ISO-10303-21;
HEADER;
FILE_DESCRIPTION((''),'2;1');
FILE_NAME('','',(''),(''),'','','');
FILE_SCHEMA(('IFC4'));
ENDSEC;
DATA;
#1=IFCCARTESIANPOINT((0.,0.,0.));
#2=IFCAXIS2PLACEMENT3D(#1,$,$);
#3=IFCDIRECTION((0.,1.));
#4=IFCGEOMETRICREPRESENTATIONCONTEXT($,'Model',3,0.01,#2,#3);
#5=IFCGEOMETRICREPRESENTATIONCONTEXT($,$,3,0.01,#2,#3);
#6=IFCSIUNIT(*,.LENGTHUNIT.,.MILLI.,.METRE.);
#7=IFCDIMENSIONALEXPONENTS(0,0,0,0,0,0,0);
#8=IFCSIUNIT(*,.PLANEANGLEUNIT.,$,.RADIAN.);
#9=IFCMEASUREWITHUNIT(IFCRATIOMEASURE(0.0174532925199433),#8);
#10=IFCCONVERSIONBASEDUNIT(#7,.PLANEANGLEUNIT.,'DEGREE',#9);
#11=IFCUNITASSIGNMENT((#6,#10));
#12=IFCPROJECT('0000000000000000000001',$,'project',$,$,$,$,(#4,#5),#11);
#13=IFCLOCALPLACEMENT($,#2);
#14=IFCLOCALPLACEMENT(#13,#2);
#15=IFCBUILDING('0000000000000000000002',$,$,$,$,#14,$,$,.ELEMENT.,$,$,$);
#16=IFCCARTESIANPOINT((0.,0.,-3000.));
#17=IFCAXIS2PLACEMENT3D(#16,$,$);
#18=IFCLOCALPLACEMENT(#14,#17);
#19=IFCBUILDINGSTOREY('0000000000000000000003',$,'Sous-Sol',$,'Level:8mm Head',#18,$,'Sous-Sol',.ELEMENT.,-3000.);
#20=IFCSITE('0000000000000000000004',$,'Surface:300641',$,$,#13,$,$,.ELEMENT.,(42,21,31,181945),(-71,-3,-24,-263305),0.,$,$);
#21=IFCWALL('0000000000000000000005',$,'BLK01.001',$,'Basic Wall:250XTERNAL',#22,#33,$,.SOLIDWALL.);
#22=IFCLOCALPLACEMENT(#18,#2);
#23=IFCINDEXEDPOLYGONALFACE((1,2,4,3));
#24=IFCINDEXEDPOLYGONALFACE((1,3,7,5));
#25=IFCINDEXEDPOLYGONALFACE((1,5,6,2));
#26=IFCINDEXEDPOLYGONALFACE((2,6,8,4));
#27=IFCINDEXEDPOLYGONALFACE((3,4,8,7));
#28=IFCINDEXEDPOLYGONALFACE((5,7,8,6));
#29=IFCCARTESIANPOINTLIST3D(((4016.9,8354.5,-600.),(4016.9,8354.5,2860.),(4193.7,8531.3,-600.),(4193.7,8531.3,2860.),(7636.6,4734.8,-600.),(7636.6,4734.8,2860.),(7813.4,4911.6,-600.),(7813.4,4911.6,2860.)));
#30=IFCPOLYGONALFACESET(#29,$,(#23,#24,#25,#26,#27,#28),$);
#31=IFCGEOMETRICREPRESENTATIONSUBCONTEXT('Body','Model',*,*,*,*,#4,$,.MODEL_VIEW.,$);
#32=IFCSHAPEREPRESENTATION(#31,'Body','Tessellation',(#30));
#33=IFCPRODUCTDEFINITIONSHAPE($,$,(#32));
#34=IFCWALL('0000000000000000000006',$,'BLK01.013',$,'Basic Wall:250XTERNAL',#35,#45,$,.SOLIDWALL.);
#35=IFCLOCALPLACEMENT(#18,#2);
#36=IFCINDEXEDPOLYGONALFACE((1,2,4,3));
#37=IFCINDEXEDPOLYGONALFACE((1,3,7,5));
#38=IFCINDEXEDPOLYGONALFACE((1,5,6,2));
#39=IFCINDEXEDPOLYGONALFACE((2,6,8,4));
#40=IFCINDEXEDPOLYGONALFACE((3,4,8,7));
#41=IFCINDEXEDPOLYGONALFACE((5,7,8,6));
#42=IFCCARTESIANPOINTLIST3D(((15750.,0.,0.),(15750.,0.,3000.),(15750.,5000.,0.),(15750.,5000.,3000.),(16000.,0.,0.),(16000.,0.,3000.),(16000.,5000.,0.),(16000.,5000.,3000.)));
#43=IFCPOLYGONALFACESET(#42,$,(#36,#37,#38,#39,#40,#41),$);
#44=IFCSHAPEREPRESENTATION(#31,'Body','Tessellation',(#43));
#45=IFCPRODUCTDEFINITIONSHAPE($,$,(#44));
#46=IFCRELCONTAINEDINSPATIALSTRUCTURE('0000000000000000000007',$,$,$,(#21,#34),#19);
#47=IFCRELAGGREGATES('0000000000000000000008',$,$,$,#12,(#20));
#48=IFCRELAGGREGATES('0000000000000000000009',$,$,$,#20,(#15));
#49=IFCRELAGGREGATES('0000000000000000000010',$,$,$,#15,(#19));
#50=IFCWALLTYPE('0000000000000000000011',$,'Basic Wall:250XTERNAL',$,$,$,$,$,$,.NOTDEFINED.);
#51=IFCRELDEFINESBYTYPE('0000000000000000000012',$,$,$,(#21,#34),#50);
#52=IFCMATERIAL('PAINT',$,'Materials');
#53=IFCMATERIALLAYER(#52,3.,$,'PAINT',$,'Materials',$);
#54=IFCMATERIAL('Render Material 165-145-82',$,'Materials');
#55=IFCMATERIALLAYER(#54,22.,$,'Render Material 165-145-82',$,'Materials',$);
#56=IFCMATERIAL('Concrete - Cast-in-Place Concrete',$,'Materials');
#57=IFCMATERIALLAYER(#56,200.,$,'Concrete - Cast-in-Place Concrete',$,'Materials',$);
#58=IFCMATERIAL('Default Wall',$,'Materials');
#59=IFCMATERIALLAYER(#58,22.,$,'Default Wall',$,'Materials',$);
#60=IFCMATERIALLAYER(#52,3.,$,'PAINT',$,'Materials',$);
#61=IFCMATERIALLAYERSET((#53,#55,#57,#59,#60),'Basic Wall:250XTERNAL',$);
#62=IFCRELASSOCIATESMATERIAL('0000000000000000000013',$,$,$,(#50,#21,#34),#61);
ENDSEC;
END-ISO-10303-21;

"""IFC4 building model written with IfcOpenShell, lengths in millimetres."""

from ifc_helpers import new_model, entity, si_unit, converted_unit, direction, frame, frame_2d, origin, place, context, subcontext, project, spatial, polyline, rectangle, extrude, clip, bounded_halfspace, material, layer, layer_set, layer_usage, type_object, element, save


model = new_model("IFC4")

# Units and contexts
model_context = context("Model", 3, precision=0.01, world=origin(), true_north=direction((0.0, 1.0)))
context_of_model = context(None, 3, precision=0.01, world=origin(), true_north=direction((0.0, 1.0)))
body_context = subcontext(model_context, "Body", "Model", "MODEL_VIEW")
ifc_project = project(units=[si_unit("LENGTHUNIT", "METRE", prefix="MILLI"), converted_unit("PLANEANGLEUNIT", "DEGREE", entity("IfcRatioMeasure", 0.0174532925199433), si_unit("PLANEANGLEUNIT", "RADIAN"), dimensions=[0, 0, 0, 0, 0, 0, 0])], contexts=[model_context, context_of_model])

# Site, building, storey
site_placement = place(None, origin())
site = spatial("IfcSite", under=ifc_project, at=site_placement, Name="Surface:300641", CompositionType="ELEMENT", RefLatitude=(42, 21, 31, 181945), RefLongitude=(-71, -3, -24, -263305), RefElevation=0.0)
building_placement = place(site_placement, origin())
building = spatial("IfcBuilding", under=site, at=building_placement, CompositionType="ELEMENT")
storey_placement = place(building_placement, frame((0.0, 0.0, -3000.0)))
storey = spatial("IfcBuildingStorey", under=building, at=storey_placement, Name="Sous-Sol", ObjectType="Level:8mm Head", LongName="Sous-Sol", CompositionType="ELEMENT", Elevation=-3000.0)

# Shared definitions
ifc_material_1 = material(Name="Concrete - Cast-in-Place Concrete", Category="Materials")

# Walls
ifc_material_2 = material(Name="PAINT", Category="Materials")
ifc_layer_1 = layer(ifc_material_2, 3.0, Name="PAINT", Category="Materials")
ifc_material_3 = material(Name="Render Material 165-145-82", Category="Materials")
ifc_layer_2 = layer(ifc_material_3, 22.0, Name="Render Material 165-145-82", Category="Materials")
ifc_layer_3 = layer(ifc_material_1, 200.0, Name="Concrete - Cast-in-Place Concrete", Category="Materials")
ifc_material_4 = material(Name="Default Wall", Category="Materials")
ifc_layer_4 = layer(ifc_material_4, 22.0, Name="Default Wall", Category="Materials")
ifc_layer_5 = layer(ifc_material_2, 3.0, Name="PAINT", Category="Materials")
ifc_layer_set = layer_set([ifc_layer_1, ifc_layer_2, ifc_layer_3, ifc_layer_4, ifc_layer_5], Name="Basic Wall:250XTERNAL")
wall_type = type_object("IfcWallType", Name="Basic Wall:250XTERNAL", PredefinedType="NOTDEFINED", material=ifc_layer_set)
ifc_layer_usage_1 = layer_usage(ifc_layer_set, "AXIS2", "NEGATIVE", 125.0)
wall_1_placement = place(storey_placement, frame((7725.0, 4823.2, -600.0), z_axis=(0.0, 0.0, 1.0), x_axis=(-0.707107, 0.707107, 0.0)))
element("IfcWall", 1, at=wall_1_placement, inside=storey, type_object=wall_type, material=ifc_layer_usage_1, Name="BLK01.001", ObjectType="Basic Wall:250XTERNAL", PredefinedType="SOLIDWALL", context=body_context, shape_type="Clipping", body=[
    clip(extrude(rectangle(XDim=5119.0, YDim=250.0, at=frame_2d((2559.5, 0.0), x_axis=(-1.0, 0.0))), origin(), (0.0, 0.0, 1.0), 3460.0), bounded_halfspace(frame((0.0, -125.0, 3460.0), z_axis=(0.0, 0.0, -1.0), x_axis=(-0.707107, -0.707107, 0.0)), True, frame((0.0, -125.0, 3460.0)), polyline([(0.0, 0.0), (4869.0, 0.0), (5119.0, 0.0), (5119.0, 250.0), (0.0, 250.0), (0.0, 0.0)]))),
])
ifc_layer_usage_2 = layer_usage(ifc_layer_set, "AXIS2", "NEGATIVE", 125.0)
wall_2_placement = place(storey_placement, frame((15875.0, 0.0, 0.0), z_axis=(0.0, 0.0, 1.0), x_axis=(0.0, 1.0, 0.0)))
element("IfcWall", 2, at=wall_2_placement, inside=storey, type_object=wall_type, material=ifc_layer_usage_2, Name="BLK01.013", ObjectType="Basic Wall:250XTERNAL", PredefinedType="SOLIDWALL", context=body_context, shape_type="SweptSolid", body=[
    extrude(rectangle(XDim=5000.0, YDim=250.0, at=frame_2d((2500.0, 0.0), x_axis=(-1.0, 0.0))), origin(), (0.0, 0.0, 1.0), 3000.0),
])

save(model, "model.ifc")
